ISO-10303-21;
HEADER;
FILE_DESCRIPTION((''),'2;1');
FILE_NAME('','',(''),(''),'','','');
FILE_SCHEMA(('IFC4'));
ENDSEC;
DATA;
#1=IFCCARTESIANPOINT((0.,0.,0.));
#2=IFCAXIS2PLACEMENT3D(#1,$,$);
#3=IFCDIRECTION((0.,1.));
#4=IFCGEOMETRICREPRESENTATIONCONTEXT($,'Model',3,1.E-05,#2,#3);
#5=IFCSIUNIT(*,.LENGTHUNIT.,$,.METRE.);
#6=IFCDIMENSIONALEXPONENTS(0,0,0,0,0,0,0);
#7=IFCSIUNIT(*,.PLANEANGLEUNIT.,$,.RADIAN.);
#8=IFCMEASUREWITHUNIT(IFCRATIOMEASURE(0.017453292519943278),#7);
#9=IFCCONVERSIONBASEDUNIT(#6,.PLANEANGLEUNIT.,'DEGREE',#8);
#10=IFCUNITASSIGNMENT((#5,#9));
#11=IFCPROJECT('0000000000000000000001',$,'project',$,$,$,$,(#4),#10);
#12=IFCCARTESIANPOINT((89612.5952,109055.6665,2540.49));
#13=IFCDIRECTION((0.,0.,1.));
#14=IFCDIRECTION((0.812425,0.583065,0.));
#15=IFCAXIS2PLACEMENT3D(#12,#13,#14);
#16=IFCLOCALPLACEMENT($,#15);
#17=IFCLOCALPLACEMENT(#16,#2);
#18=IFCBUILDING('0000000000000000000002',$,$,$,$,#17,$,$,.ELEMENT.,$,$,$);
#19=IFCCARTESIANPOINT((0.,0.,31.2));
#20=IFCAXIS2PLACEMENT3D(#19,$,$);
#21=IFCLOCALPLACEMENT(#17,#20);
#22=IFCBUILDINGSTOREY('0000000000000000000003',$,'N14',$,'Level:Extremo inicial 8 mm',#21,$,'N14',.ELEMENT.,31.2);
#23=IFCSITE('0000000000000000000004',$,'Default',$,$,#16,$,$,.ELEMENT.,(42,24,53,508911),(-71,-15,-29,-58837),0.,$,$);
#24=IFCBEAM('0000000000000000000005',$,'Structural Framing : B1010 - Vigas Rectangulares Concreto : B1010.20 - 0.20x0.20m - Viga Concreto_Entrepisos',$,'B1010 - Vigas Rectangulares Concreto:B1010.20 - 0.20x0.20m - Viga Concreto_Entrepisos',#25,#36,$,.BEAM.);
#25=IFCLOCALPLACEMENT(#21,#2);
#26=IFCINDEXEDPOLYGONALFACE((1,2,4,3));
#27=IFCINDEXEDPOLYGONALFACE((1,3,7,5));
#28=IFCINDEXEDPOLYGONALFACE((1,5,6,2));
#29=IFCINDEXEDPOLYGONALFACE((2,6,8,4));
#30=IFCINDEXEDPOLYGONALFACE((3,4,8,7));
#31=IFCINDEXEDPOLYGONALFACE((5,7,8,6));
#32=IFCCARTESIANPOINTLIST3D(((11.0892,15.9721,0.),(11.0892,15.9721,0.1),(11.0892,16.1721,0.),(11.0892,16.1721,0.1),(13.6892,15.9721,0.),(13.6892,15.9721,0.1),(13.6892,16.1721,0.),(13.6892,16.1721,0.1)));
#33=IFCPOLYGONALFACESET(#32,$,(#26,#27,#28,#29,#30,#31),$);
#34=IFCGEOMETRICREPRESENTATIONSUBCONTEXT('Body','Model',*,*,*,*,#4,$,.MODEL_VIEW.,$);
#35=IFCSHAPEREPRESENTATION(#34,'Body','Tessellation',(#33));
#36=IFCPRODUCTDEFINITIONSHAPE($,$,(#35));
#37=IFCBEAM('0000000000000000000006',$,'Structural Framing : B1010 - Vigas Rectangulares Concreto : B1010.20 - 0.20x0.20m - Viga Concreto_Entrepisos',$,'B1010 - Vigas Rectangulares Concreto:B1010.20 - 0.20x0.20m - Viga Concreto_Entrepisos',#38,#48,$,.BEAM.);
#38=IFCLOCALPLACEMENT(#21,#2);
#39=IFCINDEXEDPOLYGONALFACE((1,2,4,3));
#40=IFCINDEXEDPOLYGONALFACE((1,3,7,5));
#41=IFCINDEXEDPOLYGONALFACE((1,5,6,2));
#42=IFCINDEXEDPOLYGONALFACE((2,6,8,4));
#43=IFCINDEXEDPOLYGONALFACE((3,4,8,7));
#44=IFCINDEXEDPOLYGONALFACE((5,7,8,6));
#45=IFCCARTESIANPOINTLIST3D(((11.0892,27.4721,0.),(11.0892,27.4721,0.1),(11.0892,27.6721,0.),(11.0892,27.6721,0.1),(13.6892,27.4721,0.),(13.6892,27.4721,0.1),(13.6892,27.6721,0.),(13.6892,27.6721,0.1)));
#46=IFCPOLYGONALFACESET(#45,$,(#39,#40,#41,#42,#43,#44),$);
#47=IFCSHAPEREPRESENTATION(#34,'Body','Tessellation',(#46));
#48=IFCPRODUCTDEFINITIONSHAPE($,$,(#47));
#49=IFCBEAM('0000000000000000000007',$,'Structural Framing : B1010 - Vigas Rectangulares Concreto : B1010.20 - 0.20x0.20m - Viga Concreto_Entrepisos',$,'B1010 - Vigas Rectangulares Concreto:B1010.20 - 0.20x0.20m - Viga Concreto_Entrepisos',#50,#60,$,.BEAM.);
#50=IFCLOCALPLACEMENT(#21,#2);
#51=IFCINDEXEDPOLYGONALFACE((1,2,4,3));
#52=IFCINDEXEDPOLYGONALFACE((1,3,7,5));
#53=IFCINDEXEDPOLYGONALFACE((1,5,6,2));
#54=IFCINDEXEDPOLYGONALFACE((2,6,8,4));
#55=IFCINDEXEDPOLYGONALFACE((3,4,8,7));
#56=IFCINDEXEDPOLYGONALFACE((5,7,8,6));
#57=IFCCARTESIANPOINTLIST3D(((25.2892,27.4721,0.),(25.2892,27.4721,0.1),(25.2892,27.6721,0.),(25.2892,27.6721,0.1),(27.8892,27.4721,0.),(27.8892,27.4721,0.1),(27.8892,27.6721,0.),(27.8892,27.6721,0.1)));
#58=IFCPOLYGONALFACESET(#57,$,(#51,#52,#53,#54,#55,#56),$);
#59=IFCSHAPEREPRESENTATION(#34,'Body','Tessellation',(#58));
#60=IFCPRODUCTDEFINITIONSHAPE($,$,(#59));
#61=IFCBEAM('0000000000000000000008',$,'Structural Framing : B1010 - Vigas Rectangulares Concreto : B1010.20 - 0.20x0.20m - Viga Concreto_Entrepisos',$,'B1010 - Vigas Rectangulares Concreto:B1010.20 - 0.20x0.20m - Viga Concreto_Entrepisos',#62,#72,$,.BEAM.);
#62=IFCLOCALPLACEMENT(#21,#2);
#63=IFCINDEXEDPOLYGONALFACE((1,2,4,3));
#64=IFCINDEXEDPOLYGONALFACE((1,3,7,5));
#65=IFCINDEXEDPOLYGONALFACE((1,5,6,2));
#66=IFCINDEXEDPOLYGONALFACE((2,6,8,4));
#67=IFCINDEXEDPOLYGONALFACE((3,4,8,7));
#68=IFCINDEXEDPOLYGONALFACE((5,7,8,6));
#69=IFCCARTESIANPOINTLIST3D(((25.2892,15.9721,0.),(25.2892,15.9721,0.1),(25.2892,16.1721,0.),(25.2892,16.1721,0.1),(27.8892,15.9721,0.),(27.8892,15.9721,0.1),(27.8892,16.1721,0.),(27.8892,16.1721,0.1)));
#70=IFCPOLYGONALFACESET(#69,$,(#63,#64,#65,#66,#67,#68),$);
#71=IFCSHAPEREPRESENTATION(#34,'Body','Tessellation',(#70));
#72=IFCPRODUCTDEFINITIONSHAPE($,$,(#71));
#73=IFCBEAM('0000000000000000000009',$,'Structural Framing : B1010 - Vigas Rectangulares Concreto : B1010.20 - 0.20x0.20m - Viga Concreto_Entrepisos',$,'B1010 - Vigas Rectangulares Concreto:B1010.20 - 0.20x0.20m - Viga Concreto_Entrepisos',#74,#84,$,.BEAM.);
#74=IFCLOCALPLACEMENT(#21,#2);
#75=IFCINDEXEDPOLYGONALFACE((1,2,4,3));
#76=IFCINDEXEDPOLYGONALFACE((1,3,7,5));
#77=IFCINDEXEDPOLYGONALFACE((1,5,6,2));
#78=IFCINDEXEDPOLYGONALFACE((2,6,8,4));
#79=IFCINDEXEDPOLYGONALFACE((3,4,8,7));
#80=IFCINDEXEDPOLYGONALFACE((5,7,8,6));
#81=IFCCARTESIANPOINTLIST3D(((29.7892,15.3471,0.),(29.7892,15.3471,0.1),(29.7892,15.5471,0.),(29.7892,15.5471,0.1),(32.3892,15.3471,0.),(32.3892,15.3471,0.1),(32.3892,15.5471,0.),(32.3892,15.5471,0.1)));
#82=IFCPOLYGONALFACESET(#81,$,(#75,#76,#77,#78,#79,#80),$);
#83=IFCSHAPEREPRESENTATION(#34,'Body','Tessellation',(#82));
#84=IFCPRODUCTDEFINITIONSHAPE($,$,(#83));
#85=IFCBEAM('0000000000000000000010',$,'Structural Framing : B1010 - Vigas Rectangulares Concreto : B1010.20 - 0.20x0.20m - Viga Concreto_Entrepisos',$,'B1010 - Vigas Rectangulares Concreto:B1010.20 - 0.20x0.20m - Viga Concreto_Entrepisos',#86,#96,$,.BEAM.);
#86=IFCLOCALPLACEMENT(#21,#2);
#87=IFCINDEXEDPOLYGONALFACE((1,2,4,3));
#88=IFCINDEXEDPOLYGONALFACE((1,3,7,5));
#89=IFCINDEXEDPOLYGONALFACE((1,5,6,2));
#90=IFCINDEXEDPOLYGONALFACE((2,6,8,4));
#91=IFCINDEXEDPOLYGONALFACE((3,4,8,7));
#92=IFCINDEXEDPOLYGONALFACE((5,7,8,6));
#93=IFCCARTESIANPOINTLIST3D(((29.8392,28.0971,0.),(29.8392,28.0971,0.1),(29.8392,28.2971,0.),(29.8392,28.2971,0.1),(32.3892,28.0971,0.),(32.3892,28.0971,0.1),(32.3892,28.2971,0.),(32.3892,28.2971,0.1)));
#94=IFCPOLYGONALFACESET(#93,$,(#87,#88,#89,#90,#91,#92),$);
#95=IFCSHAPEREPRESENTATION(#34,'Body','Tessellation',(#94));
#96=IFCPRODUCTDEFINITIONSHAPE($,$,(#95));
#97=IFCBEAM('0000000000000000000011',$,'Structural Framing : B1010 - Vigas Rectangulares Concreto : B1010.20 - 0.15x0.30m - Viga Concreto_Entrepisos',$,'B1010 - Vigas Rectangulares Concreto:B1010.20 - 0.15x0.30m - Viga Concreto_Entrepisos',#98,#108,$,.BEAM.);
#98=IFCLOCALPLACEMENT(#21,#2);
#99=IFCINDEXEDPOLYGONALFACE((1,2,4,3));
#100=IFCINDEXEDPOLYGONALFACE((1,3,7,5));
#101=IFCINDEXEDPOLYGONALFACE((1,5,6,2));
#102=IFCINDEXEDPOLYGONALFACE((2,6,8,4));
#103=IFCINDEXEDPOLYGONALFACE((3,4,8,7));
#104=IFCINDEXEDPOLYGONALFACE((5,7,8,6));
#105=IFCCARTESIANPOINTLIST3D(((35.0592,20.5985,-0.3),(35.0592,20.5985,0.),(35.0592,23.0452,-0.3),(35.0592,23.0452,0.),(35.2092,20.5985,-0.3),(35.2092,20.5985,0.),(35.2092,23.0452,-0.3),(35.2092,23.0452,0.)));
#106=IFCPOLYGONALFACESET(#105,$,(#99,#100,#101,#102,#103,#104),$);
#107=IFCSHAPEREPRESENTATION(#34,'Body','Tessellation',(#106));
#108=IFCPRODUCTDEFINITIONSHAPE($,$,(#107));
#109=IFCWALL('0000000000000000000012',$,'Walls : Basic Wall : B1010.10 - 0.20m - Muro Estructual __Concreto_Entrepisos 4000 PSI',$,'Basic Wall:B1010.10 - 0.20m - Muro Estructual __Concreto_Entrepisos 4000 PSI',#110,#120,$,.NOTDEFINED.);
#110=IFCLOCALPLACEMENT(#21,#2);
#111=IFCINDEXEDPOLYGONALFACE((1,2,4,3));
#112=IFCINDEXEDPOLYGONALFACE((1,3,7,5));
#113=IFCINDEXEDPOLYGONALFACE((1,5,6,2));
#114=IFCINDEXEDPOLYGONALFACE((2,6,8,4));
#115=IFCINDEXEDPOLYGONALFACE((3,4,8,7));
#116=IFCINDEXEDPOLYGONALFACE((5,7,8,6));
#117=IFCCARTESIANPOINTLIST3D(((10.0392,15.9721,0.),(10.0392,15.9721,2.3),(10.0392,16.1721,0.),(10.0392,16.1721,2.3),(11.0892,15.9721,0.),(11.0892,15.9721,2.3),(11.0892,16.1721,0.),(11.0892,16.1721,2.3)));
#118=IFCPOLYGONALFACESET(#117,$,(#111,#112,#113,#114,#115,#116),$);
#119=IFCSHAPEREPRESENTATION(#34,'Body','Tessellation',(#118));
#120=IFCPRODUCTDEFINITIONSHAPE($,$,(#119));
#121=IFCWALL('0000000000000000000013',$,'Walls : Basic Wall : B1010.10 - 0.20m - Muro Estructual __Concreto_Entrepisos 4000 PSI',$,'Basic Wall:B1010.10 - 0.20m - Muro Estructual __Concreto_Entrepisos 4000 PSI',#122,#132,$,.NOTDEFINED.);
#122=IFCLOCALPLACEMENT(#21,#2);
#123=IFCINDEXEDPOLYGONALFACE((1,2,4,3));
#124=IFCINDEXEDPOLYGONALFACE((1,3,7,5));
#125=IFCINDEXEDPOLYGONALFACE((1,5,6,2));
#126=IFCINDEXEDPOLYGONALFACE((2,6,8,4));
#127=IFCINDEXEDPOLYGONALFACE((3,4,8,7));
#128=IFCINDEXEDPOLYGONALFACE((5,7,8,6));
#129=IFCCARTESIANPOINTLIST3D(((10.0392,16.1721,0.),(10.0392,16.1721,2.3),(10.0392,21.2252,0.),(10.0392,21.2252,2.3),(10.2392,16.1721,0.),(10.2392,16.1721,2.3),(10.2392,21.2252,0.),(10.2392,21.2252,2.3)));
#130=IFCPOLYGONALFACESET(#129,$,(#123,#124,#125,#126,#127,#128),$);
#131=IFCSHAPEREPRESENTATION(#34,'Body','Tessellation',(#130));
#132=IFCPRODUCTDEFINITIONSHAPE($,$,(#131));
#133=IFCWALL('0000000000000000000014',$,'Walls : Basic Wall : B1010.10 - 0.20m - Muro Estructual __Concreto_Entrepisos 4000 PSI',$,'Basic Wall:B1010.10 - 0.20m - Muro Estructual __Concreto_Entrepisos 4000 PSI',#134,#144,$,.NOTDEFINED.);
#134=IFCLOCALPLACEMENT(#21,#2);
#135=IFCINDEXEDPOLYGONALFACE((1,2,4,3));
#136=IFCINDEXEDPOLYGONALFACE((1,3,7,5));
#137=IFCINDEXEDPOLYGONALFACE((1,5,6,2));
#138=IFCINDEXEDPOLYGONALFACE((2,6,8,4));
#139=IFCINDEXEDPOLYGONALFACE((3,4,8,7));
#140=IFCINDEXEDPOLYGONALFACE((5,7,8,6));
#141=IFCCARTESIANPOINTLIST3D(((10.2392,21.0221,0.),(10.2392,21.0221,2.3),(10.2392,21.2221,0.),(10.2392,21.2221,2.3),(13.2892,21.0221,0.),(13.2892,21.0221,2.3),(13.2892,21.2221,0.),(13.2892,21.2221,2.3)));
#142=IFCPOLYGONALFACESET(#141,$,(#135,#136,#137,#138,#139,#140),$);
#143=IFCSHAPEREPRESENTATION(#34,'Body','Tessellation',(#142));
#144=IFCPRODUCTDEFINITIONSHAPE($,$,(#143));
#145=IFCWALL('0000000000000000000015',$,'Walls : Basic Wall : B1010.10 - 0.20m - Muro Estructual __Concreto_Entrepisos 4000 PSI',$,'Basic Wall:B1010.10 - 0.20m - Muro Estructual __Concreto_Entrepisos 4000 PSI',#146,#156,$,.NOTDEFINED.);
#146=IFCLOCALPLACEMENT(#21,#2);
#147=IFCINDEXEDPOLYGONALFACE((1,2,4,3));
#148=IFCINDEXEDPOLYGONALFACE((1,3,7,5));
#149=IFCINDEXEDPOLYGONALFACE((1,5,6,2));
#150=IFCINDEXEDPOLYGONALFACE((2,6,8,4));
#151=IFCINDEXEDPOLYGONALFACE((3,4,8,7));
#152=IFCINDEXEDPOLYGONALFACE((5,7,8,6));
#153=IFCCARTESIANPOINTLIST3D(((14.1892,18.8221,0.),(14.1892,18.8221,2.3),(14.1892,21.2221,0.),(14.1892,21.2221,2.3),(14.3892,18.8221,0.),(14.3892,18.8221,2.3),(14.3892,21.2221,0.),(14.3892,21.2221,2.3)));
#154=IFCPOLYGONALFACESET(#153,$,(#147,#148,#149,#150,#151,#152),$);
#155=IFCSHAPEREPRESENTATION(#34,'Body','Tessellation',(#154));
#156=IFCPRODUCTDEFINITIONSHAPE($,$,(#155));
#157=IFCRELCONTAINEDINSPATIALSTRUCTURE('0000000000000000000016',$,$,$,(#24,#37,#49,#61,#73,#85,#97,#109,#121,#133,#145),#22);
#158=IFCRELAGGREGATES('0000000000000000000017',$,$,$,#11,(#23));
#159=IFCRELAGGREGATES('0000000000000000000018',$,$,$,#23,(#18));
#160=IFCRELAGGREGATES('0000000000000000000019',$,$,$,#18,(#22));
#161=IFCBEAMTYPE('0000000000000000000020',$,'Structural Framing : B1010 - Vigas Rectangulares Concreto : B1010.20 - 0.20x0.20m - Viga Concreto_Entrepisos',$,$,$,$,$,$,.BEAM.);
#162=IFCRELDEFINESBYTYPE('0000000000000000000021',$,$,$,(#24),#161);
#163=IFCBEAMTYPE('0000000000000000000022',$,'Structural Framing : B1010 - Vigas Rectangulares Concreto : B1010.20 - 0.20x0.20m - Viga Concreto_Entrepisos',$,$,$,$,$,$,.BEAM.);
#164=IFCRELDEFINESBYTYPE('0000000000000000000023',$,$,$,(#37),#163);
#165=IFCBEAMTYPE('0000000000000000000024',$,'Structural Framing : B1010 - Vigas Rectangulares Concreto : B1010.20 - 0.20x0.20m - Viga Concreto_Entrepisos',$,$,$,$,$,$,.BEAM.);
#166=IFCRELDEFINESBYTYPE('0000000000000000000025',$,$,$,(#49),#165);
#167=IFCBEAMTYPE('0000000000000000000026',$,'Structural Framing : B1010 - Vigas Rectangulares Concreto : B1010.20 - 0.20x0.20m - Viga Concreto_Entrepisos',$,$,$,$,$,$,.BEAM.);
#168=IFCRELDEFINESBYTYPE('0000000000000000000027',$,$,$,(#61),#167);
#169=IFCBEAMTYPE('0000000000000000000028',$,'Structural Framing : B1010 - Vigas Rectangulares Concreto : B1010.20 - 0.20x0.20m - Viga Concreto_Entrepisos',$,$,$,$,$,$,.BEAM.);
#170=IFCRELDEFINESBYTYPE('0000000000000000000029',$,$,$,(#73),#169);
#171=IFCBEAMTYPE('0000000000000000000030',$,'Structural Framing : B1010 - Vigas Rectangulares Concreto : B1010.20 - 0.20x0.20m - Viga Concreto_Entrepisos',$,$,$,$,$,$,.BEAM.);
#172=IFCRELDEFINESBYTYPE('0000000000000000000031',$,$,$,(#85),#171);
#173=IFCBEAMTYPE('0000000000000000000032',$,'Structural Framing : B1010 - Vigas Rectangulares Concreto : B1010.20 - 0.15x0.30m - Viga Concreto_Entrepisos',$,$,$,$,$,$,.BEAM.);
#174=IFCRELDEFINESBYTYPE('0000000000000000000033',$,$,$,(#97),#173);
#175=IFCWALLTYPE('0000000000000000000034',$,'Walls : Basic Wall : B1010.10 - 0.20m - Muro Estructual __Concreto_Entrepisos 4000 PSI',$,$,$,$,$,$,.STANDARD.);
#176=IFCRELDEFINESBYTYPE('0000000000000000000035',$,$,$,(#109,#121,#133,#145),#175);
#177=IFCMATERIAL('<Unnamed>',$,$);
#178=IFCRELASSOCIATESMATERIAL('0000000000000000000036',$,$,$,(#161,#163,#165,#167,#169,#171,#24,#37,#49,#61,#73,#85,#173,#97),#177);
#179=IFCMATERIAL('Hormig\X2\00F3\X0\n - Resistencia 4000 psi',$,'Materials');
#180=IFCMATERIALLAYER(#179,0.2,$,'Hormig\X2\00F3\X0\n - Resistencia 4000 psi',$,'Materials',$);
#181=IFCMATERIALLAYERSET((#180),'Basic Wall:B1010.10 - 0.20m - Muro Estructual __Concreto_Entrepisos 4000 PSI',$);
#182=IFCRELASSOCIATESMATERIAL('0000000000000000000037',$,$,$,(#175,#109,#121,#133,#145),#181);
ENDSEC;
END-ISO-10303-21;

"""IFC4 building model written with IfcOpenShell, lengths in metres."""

from ifc_helpers import new_model, entity, si_unit, converted_unit, direction, frame, frame_2d, origin, place, context, subcontext, project, spatial, polyline, segment, composite_curve, rectangle, outline, extrude, source, transform, mapped, material, layer, layer_set, layer_usage, material_profile, profile_set, profile_usage, type_object, type_shapes, element, save


model = new_model("IFC4")

# Units and contexts
model_context = context("Model", 3, precision=1e-05, world=origin(), true_north=direction((0.0, 1.0)))
body_context = subcontext(model_context, "Body", "Model", "MODEL_VIEW")
ifc_project = project(units=[si_unit("LENGTHUNIT", "METRE"), converted_unit("PLANEANGLEUNIT", "DEGREE", entity("IfcRatioMeasure", 0.017453292519943278), si_unit("PLANEANGLEUNIT", "RADIAN"), dimensions=[0, 0, 0, 0, 0, 0, 0])], contexts=[model_context])

# Site, building, storey
site_placement = place(None, frame((89612.5952, 109055.6665, 2540.49), z_axis=(0.0, 0.0, 1.0), x_axis=(0.812425, 0.583065, 0.0)))
site = spatial("IfcSite", under=ifc_project, at=site_placement, Name="Default", CompositionType="ELEMENT", RefLatitude=(42, 24, 53, 508911), RefLongitude=(-71, -15, -29, -58837), RefElevation=0.0)
building_placement = place(site_placement, origin())
building = spatial("IfcBuilding", under=site, at=building_placement, CompositionType="ELEMENT")
storey_placement = place(building_placement, frame((0.0, 0.0, 31.2)))
storey = spatial("IfcBuildingStorey", under=building, at=storey_placement, Name="N14", ObjectType="Level:Extremo inicial 8 mm", LongName="N14", CompositionType="ELEMENT", Elevation=31.2)

# Beams
ifc_material_1 = material(Name="<Unnamed>")
ifc_material_profile_1 = material_profile(ifc_material_1, outline(composite_curve([segment(polyline([(-0.1, 0.0, 0.0), (-0.1, 0.1, 0.0)]), True, "CONTINUOUS"), segment(polyline([(-0.1, 0.1, 0.0), (0.1, 0.1, 0.0)]), True, "CONTINUOUS"), segment(polyline([(0.1, 0.1, 0.0), (0.1, 0.0, 0.0)]), True, "CONTINUOUS"), segment(polyline([(0.1, 0.0, 0.0), (-0.1, 0.0, 0.0)]), True, "CONTINUOUS")], self_intersect=False), kind="CURVE"), Name="B1010.20 - 0.20x0.20m - Viga Concreto_Entrepisos")
ifc_material_profile_2 = material_profile(ifc_material_1, outline(composite_curve([segment(polyline([(-1.3, -0.1, 0.1), (-1.3, 0.1, 0.1)]), True, "CONTINUOUS"), segment(polyline([(-1.3, 0.1, 0.1), (-1.3, 0.1, -0.1)]), True, "CONTINUOUS"), segment(polyline([(-1.3, 0.1, -0.1), (-1.3, -0.1, -0.1)]), True, "CONTINUOUS"), segment(polyline([(-1.3, -0.1, -0.1), (-1.3, -0.1, 0.1)]), True, "CONTINUOUS")], self_intersect=False), kind="CURVE"), Name="B1010.20 - 0.20x0.20m - Viga Concreto_Entrepisos")
ifc_profile_set_1 = profile_set([ifc_material_profile_1, ifc_material_profile_2], Name="B1010.20 - 0.20x0.20m - Viga Concreto_Entrepisos")
ifc_profile_usage_1 = profile_usage(ifc_profile_set_1, cardinal=8)
beam_type_1 = type_object("IfcBeamType", Name="Structural Framing : B1010 - Vigas Rectangulares Concreto : B1010.20 - 0.20x0.20m - Viga Concreto_Entrepisos", PredefinedType="BEAM", material=ifc_profile_set_1)
shared_shape_1 = source(origin(), body_context, "Body", "SweptSolid", [
    extrude(rectangle(XDim=0.1, YDim=0.2, at=frame_2d((0.0, 0.0), x_axis=(1.0, 0.0))), frame((13.6892, 16.0721, 31.25), z_axis=(-1.0, 0.0, 0.0), x_axis=(0.0, 0.0, -1.0)), (0.0, 0.0, 1.0), 2.6),
])
type_shapes(beam_type_1, [shared_shape_1])
beam_1_placement = place(storey_placement, frame((0.0, 0.0, -31.2)))
element("IfcBeam", 1, at=beam_1_placement, inside=storey, type_object=beam_type_1, material=ifc_profile_usage_1, Name="Structural Framing : B1010 - Vigas Rectangulares Concreto : B1010.20 - 0.20x0.20m - Viga Concreto_Entrepisos", ObjectType="B1010 - Vigas Rectangulares Concreto:B1010.20 - 0.20x0.20m - Viga Concreto_Entrepisos", PredefinedType="BEAM", context=body_context, shape_type="MappedRepresentation", body=[
    mapped(shared_shape_1, transform((0.0, 0.0, 0.0), scale=1.0)),
])
ifc_profile_usage_2 = profile_usage(ifc_profile_set_1, cardinal=8)
beam_type_2 = type_object("IfcBeamType", Name="Structural Framing : B1010 - Vigas Rectangulares Concreto : B1010.20 - 0.20x0.20m - Viga Concreto_Entrepisos", PredefinedType="BEAM", material=ifc_profile_set_1)
shared_shape_2 = source(origin(), body_context, "Body", "SweptSolid", [
    extrude(rectangle(XDim=0.1, YDim=0.2, at=frame_2d((0.0, 0.0), x_axis=(1.0, 0.0))), frame((13.6892, 27.5721, 31.25), z_axis=(-1.0, 0.0, 0.0), x_axis=(0.0, 0.0, -1.0)), (0.0, 0.0, 1.0), 2.6),
])
type_shapes(beam_type_2, [shared_shape_2])
beam_2_placement = place(storey_placement, frame((0.0, 0.0, -31.2)))
element("IfcBeam", 2, at=beam_2_placement, inside=storey, type_object=beam_type_2, material=ifc_profile_usage_2, Name="Structural Framing : B1010 - Vigas Rectangulares Concreto : B1010.20 - 0.20x0.20m - Viga Concreto_Entrepisos", ObjectType="B1010 - Vigas Rectangulares Concreto:B1010.20 - 0.20x0.20m - Viga Concreto_Entrepisos", PredefinedType="BEAM", context=body_context, shape_type="MappedRepresentation", body=[
    mapped(shared_shape_2, transform((0.0, 0.0, 0.0), scale=1.0)),
])
ifc_profile_usage_3 = profile_usage(ifc_profile_set_1, cardinal=8)
beam_type_3 = type_object("IfcBeamType", Name="Structural Framing : B1010 - Vigas Rectangulares Concreto : B1010.20 - 0.20x0.20m - Viga Concreto_Entrepisos", PredefinedType="BEAM", material=ifc_profile_set_1)
shared_shape_3 = source(origin(), body_context, "Body", "SweptSolid", [
    extrude(rectangle(XDim=0.1, YDim=0.2, at=frame_2d((0.0, 0.0), x_axis=(1.0, 0.0))), frame((25.2892, 27.5721, 31.25), z_axis=(1.0, 0.0, 0.0), x_axis=(0.0, 0.0, -1.0)), (0.0, 0.0, 1.0), 2.6),
])
type_shapes(beam_type_3, [shared_shape_3])
beam_3_placement = place(storey_placement, frame((0.0, 0.0, -31.2)))
element("IfcBeam", 3, at=beam_3_placement, inside=storey, type_object=beam_type_3, material=ifc_profile_usage_3, Name="Structural Framing : B1010 - Vigas Rectangulares Concreto : B1010.20 - 0.20x0.20m - Viga Concreto_Entrepisos", ObjectType="B1010 - Vigas Rectangulares Concreto:B1010.20 - 0.20x0.20m - Viga Concreto_Entrepisos", PredefinedType="BEAM", context=body_context, shape_type="MappedRepresentation", body=[
    mapped(shared_shape_3, transform((0.0, 0.0, 0.0), scale=1.0)),
])
ifc_profile_usage_4 = profile_usage(ifc_profile_set_1, cardinal=8)
beam_type_4 = type_object("IfcBeamType", Name="Structural Framing : B1010 - Vigas Rectangulares Concreto : B1010.20 - 0.20x0.20m - Viga Concreto_Entrepisos", PredefinedType="BEAM", material=ifc_profile_set_1)
shared_shape_4 = source(origin(), body_context, "Body", "SweptSolid", [
    extrude(rectangle(XDim=0.1, YDim=0.2, at=frame_2d((0.0, 0.0), x_axis=(1.0, 0.0))), frame((25.2892, 16.0721, 31.25), z_axis=(1.0, 0.0, 0.0), x_axis=(0.0, 0.0, -1.0)), (0.0, 0.0, 1.0), 2.6),
])
type_shapes(beam_type_4, [shared_shape_4])
beam_4_placement = place(storey_placement, frame((0.0, 0.0, -31.2)))
element("IfcBeam", 4, at=beam_4_placement, inside=storey, type_object=beam_type_4, material=ifc_profile_usage_4, Name="Structural Framing : B1010 - Vigas Rectangulares Concreto : B1010.20 - 0.20x0.20m - Viga Concreto_Entrepisos", ObjectType="B1010 - Vigas Rectangulares Concreto:B1010.20 - 0.20x0.20m - Viga Concreto_Entrepisos", PredefinedType="BEAM", context=body_context, shape_type="MappedRepresentation", body=[
    mapped(shared_shape_4, transform((0.0, 0.0, 0.0), scale=1.0)),
])
ifc_profile_usage_5 = profile_usage(ifc_profile_set_1, cardinal=8)
beam_type_5 = type_object("IfcBeamType", Name="Structural Framing : B1010 - Vigas Rectangulares Concreto : B1010.20 - 0.20x0.20m - Viga Concreto_Entrepisos", PredefinedType="BEAM", material=ifc_profile_set_1)
shared_shape_5 = source(origin(), body_context, "Body", "SweptSolid", [
    extrude(rectangle(XDim=0.1, YDim=0.2, at=frame_2d((0.0, 0.0), x_axis=(1.0, 0.0))), frame((32.3892, 15.4471, 31.25), z_axis=(-1.0, 0.0, 0.0), x_axis=(0.0, 0.0, -1.0)), (0.0, 0.0, 1.0), 2.6),
])
type_shapes(beam_type_5, [shared_shape_5])
beam_5_placement = place(storey_placement, frame((0.0, 0.0, -31.2)))
element("IfcBeam", 5, at=beam_5_placement, inside=storey, type_object=beam_type_5, material=ifc_profile_usage_5, Name="Structural Framing : B1010 - Vigas Rectangulares Concreto : B1010.20 - 0.20x0.20m - Viga Concreto_Entrepisos", ObjectType="B1010 - Vigas Rectangulares Concreto:B1010.20 - 0.20x0.20m - Viga Concreto_Entrepisos", PredefinedType="BEAM", context=body_context, shape_type="MappedRepresentation", body=[
    mapped(shared_shape_5, transform((0.0, 0.0, 0.0), scale=1.0)),
])
ifc_profile_usage_6 = profile_usage(ifc_profile_set_1, cardinal=8)
beam_type_6 = type_object("IfcBeamType", Name="Structural Framing : B1010 - Vigas Rectangulares Concreto : B1010.20 - 0.20x0.20m - Viga Concreto_Entrepisos", PredefinedType="BEAM", material=ifc_profile_set_1)
shared_shape_6 = source(origin(), body_context, "Body", "SweptSolid", [
    extrude(rectangle(XDim=0.1, YDim=0.2, at=frame_2d((0.0, 0.0), x_axis=(1.0, 0.0))), frame((29.8392, 28.1971, 31.25), z_axis=(1.0, 0.0, 0.0), x_axis=(0.0, 0.0, -1.0)), (0.0, 0.0, 1.0), 2.55),
])
type_shapes(beam_type_6, [shared_shape_6])
beam_6_placement = place(storey_placement, frame((0.0, 0.0, -31.2)))
element("IfcBeam", 6, at=beam_6_placement, inside=storey, type_object=beam_type_6, material=ifc_profile_usage_6, Name="Structural Framing : B1010 - Vigas Rectangulares Concreto : B1010.20 - 0.20x0.20m - Viga Concreto_Entrepisos", ObjectType="B1010 - Vigas Rectangulares Concreto:B1010.20 - 0.20x0.20m - Viga Concreto_Entrepisos", PredefinedType="BEAM", context=body_context, shape_type="MappedRepresentation", body=[
    mapped(shared_shape_6, transform((0.0, 0.0, 0.0), scale=1.0)),
])
ifc_material_profile_3 = material_profile(ifc_material_1, outline(composite_curve([segment(polyline([(-0.075, -0.15, 0.0), (-0.075, 0.15, 0.0)]), True, "CONTINUOUS"), segment(polyline([(-0.075, 0.15, 0.0), (0.075, 0.15, 0.0)]), True, "CONTINUOUS"), segment(polyline([(0.075, 0.15, 0.0), (0.075, -0.15, 0.0)]), True, "CONTINUOUS"), segment(polyline([(0.075, -0.15, 0.0), (-0.075, -0.15, 0.0)]), True, "CONTINUOUS")], self_intersect=False), kind="CURVE"), Name="B1010.20 - 0.15x0.30m - Viga Concreto_Entrepisos")
ifc_material_profile_4 = material_profile(ifc_material_1, outline(composite_curve([segment(polyline([(1.2233, 0.075, 0.15), (1.2233, 0.075, -0.15)]), True, "CONTINUOUS"), segment(polyline([(1.2233, 0.075, -0.15), (-1.2233, 0.075, -0.15)]), True, "CONTINUOUS"), segment(polyline([(-1.2233, 0.075, -0.15), (-1.2233, 0.075, 0.15)]), True, "CONTINUOUS"), segment(polyline([(-1.2233, 0.075, 0.15), (1.2233, 0.075, 0.15)]), True, "CONTINUOUS")], self_intersect=False), kind="CURVE"), Name="B1010.20 - 0.15x0.30m - Viga Concreto_Entrepisos")
ifc_profile_set_2 = profile_set([ifc_material_profile_3, ifc_material_profile_4], Name="B1010.20 - 0.15x0.30m - Viga Concreto_Entrepisos")
ifc_profile_usage_7 = profile_usage(ifc_profile_set_2, cardinal=8)
beam_type_7 = type_object("IfcBeamType", Name="Structural Framing : B1010 - Vigas Rectangulares Concreto : B1010.20 - 0.15x0.30m - Viga Concreto_Entrepisos", PredefinedType="BEAM", material=ifc_profile_set_2)
shared_shape_7 = source(origin(), body_context, "Body", "SweptSolid", [
    extrude(rectangle(XDim=0.3, YDim=0.15, at=frame_2d((0.0, 0.0), x_axis=(0.0, 1.0))), frame((35.1342, 20.5985, 31.05), z_axis=(0.0, 1.0, 0.0), x_axis=(-1.0, 0.0, 0.0)), (0.0, 0.0, 1.0), 2.4467),
])
type_shapes(beam_type_7, [shared_shape_7])
beam_7_placement = place(storey_placement, frame((0.0, 0.0, -31.2)))
element("IfcBeam", 7, at=beam_7_placement, inside=storey, type_object=beam_type_7, material=ifc_profile_usage_7, Name="Structural Framing : B1010 - Vigas Rectangulares Concreto : B1010.20 - 0.15x0.30m - Viga Concreto_Entrepisos", ObjectType="B1010 - Vigas Rectangulares Concreto:B1010.20 - 0.15x0.30m - Viga Concreto_Entrepisos", PredefinedType="BEAM", context=body_context, shape_type="MappedRepresentation", body=[
    mapped(shared_shape_7, transform((0.0, 0.0, 0.0), scale=1.0)),
])

# Walls
ifc_material_2 = material(Name="Hormigón - Resistencia 4000 psi", Category="Materials")
ifc_layer_1 = layer(ifc_material_2, 0.2, Name="Hormigón - Resistencia 4000 psi", Category="Materials")
ifc_layer_set_1 = layer_set([ifc_layer_1], Name="Basic Wall:B1010.10 - 0.20m - Muro Estructual __Concreto_Entrepisos 4000 PSI")
ifc_layer_usage_1 = layer_usage(ifc_layer_set_1, "AXIS2", "NEGATIVE", 0.1)
wall_type_1 = type_object("IfcWallType", Name="Walls : Basic Wall : B1010.10 - 0.20m - Muro Estructual __Concreto_Entrepisos 4000 PSI", PredefinedType="STANDARD", material=ifc_layer_set_1)
wall_1_placement = place(storey_placement, frame((11.0892, 16.0721, 0.0), z_axis=(0.0, 0.0, 1.0), x_axis=(-1.0, 0.0, 0.0)))
element("IfcWall", 8, at=wall_1_placement, inside=storey, type_object=wall_type_1, material=ifc_layer_usage_1, Name="Walls : Basic Wall : B1010.10 - 0.20m - Muro Estructual __Concreto_Entrepisos 4000 PSI", ObjectType="Basic Wall:B1010.10 - 0.20m - Muro Estructual __Concreto_Entrepisos 4000 PSI", PredefinedType="NOTDEFINED", context=body_context, shape_type="SweptSolid", body=[
    extrude(rectangle(XDim=1.05, YDim=0.2, at=frame_2d((0.525, 0.0), x_axis=(-1.0, 0.0))), origin(), (0.0, 0.0, 1.0), 2.3),
])
ifc_layer_usage_2 = layer_usage(ifc_layer_set_1, "AXIS2", "NEGATIVE", 0.1)
wall_2_placement = place(storey_placement, frame((10.1392, 16.1721, 0.0), z_axis=(0.0, 0.0, 1.0), x_axis=(0.0, 1.0, 0.0)))
element("IfcWall", 9, at=wall_2_placement, inside=storey, type_object=wall_type_1, material=ifc_layer_usage_2, Name="Walls : Basic Wall : B1010.10 - 0.20m - Muro Estructual __Concreto_Entrepisos 4000 PSI", ObjectType="Basic Wall:B1010.10 - 0.20m - Muro Estructual __Concreto_Entrepisos 4000 PSI", PredefinedType="NOTDEFINED", context=body_context, shape_type="SweptSolid", body=[
    extrude(rectangle(XDim=5.0531, YDim=0.2, at=frame_2d((2.5265, 0.0), x_axis=(-1.0, 0.0))), origin(), (0.0, 0.0, 1.0), 2.3),
])
ifc_layer_usage_3 = layer_usage(ifc_layer_set_1, "AXIS2", "NEGATIVE", 0.1)
wall_3_placement = place(storey_placement, frame((10.2392, 21.1221, 0.0)))
element("IfcWall", 10, at=wall_3_placement, inside=storey, type_object=wall_type_1, material=ifc_layer_usage_3, Name="Walls : Basic Wall : B1010.10 - 0.20m - Muro Estructual __Concreto_Entrepisos 4000 PSI", ObjectType="Basic Wall:B1010.10 - 0.20m - Muro Estructual __Concreto_Entrepisos 4000 PSI", PredefinedType="NOTDEFINED", context=body_context, shape_type="SweptSolid", body=[
    extrude(rectangle(XDim=3.05, YDim=0.2, at=frame_2d((1.525, 0.0), x_axis=(-1.0, 0.0))), origin(), (0.0, 0.0, 1.0), 2.3),
])
ifc_layer_usage_4 = layer_usage(ifc_layer_set_1, "AXIS2", "NEGATIVE", 0.1)
wall_4_placement = place(storey_placement, frame((14.2892, 18.8221, 0.0), z_axis=(0.0, 0.0, 1.0), x_axis=(0.0, 1.0, 0.0)))
element("IfcWall", 11, at=wall_4_placement, inside=storey, type_object=wall_type_1, material=ifc_layer_usage_4, Name="Walls : Basic Wall : B1010.10 - 0.20m - Muro Estructual __Concreto_Entrepisos 4000 PSI", ObjectType="Basic Wall:B1010.10 - 0.20m - Muro Estructual __Concreto_Entrepisos 4000 PSI", PredefinedType="NOTDEFINED", context=body_context, shape_type="SweptSolid", body=[
    extrude(rectangle(XDim=2.4, YDim=0.2, at=frame_2d((1.2, 0.0), x_axis=(-1.0, 0.0))), origin(), (0.0, 0.0, 1.0), 2.3),
])

save(model, "model.ifc")
